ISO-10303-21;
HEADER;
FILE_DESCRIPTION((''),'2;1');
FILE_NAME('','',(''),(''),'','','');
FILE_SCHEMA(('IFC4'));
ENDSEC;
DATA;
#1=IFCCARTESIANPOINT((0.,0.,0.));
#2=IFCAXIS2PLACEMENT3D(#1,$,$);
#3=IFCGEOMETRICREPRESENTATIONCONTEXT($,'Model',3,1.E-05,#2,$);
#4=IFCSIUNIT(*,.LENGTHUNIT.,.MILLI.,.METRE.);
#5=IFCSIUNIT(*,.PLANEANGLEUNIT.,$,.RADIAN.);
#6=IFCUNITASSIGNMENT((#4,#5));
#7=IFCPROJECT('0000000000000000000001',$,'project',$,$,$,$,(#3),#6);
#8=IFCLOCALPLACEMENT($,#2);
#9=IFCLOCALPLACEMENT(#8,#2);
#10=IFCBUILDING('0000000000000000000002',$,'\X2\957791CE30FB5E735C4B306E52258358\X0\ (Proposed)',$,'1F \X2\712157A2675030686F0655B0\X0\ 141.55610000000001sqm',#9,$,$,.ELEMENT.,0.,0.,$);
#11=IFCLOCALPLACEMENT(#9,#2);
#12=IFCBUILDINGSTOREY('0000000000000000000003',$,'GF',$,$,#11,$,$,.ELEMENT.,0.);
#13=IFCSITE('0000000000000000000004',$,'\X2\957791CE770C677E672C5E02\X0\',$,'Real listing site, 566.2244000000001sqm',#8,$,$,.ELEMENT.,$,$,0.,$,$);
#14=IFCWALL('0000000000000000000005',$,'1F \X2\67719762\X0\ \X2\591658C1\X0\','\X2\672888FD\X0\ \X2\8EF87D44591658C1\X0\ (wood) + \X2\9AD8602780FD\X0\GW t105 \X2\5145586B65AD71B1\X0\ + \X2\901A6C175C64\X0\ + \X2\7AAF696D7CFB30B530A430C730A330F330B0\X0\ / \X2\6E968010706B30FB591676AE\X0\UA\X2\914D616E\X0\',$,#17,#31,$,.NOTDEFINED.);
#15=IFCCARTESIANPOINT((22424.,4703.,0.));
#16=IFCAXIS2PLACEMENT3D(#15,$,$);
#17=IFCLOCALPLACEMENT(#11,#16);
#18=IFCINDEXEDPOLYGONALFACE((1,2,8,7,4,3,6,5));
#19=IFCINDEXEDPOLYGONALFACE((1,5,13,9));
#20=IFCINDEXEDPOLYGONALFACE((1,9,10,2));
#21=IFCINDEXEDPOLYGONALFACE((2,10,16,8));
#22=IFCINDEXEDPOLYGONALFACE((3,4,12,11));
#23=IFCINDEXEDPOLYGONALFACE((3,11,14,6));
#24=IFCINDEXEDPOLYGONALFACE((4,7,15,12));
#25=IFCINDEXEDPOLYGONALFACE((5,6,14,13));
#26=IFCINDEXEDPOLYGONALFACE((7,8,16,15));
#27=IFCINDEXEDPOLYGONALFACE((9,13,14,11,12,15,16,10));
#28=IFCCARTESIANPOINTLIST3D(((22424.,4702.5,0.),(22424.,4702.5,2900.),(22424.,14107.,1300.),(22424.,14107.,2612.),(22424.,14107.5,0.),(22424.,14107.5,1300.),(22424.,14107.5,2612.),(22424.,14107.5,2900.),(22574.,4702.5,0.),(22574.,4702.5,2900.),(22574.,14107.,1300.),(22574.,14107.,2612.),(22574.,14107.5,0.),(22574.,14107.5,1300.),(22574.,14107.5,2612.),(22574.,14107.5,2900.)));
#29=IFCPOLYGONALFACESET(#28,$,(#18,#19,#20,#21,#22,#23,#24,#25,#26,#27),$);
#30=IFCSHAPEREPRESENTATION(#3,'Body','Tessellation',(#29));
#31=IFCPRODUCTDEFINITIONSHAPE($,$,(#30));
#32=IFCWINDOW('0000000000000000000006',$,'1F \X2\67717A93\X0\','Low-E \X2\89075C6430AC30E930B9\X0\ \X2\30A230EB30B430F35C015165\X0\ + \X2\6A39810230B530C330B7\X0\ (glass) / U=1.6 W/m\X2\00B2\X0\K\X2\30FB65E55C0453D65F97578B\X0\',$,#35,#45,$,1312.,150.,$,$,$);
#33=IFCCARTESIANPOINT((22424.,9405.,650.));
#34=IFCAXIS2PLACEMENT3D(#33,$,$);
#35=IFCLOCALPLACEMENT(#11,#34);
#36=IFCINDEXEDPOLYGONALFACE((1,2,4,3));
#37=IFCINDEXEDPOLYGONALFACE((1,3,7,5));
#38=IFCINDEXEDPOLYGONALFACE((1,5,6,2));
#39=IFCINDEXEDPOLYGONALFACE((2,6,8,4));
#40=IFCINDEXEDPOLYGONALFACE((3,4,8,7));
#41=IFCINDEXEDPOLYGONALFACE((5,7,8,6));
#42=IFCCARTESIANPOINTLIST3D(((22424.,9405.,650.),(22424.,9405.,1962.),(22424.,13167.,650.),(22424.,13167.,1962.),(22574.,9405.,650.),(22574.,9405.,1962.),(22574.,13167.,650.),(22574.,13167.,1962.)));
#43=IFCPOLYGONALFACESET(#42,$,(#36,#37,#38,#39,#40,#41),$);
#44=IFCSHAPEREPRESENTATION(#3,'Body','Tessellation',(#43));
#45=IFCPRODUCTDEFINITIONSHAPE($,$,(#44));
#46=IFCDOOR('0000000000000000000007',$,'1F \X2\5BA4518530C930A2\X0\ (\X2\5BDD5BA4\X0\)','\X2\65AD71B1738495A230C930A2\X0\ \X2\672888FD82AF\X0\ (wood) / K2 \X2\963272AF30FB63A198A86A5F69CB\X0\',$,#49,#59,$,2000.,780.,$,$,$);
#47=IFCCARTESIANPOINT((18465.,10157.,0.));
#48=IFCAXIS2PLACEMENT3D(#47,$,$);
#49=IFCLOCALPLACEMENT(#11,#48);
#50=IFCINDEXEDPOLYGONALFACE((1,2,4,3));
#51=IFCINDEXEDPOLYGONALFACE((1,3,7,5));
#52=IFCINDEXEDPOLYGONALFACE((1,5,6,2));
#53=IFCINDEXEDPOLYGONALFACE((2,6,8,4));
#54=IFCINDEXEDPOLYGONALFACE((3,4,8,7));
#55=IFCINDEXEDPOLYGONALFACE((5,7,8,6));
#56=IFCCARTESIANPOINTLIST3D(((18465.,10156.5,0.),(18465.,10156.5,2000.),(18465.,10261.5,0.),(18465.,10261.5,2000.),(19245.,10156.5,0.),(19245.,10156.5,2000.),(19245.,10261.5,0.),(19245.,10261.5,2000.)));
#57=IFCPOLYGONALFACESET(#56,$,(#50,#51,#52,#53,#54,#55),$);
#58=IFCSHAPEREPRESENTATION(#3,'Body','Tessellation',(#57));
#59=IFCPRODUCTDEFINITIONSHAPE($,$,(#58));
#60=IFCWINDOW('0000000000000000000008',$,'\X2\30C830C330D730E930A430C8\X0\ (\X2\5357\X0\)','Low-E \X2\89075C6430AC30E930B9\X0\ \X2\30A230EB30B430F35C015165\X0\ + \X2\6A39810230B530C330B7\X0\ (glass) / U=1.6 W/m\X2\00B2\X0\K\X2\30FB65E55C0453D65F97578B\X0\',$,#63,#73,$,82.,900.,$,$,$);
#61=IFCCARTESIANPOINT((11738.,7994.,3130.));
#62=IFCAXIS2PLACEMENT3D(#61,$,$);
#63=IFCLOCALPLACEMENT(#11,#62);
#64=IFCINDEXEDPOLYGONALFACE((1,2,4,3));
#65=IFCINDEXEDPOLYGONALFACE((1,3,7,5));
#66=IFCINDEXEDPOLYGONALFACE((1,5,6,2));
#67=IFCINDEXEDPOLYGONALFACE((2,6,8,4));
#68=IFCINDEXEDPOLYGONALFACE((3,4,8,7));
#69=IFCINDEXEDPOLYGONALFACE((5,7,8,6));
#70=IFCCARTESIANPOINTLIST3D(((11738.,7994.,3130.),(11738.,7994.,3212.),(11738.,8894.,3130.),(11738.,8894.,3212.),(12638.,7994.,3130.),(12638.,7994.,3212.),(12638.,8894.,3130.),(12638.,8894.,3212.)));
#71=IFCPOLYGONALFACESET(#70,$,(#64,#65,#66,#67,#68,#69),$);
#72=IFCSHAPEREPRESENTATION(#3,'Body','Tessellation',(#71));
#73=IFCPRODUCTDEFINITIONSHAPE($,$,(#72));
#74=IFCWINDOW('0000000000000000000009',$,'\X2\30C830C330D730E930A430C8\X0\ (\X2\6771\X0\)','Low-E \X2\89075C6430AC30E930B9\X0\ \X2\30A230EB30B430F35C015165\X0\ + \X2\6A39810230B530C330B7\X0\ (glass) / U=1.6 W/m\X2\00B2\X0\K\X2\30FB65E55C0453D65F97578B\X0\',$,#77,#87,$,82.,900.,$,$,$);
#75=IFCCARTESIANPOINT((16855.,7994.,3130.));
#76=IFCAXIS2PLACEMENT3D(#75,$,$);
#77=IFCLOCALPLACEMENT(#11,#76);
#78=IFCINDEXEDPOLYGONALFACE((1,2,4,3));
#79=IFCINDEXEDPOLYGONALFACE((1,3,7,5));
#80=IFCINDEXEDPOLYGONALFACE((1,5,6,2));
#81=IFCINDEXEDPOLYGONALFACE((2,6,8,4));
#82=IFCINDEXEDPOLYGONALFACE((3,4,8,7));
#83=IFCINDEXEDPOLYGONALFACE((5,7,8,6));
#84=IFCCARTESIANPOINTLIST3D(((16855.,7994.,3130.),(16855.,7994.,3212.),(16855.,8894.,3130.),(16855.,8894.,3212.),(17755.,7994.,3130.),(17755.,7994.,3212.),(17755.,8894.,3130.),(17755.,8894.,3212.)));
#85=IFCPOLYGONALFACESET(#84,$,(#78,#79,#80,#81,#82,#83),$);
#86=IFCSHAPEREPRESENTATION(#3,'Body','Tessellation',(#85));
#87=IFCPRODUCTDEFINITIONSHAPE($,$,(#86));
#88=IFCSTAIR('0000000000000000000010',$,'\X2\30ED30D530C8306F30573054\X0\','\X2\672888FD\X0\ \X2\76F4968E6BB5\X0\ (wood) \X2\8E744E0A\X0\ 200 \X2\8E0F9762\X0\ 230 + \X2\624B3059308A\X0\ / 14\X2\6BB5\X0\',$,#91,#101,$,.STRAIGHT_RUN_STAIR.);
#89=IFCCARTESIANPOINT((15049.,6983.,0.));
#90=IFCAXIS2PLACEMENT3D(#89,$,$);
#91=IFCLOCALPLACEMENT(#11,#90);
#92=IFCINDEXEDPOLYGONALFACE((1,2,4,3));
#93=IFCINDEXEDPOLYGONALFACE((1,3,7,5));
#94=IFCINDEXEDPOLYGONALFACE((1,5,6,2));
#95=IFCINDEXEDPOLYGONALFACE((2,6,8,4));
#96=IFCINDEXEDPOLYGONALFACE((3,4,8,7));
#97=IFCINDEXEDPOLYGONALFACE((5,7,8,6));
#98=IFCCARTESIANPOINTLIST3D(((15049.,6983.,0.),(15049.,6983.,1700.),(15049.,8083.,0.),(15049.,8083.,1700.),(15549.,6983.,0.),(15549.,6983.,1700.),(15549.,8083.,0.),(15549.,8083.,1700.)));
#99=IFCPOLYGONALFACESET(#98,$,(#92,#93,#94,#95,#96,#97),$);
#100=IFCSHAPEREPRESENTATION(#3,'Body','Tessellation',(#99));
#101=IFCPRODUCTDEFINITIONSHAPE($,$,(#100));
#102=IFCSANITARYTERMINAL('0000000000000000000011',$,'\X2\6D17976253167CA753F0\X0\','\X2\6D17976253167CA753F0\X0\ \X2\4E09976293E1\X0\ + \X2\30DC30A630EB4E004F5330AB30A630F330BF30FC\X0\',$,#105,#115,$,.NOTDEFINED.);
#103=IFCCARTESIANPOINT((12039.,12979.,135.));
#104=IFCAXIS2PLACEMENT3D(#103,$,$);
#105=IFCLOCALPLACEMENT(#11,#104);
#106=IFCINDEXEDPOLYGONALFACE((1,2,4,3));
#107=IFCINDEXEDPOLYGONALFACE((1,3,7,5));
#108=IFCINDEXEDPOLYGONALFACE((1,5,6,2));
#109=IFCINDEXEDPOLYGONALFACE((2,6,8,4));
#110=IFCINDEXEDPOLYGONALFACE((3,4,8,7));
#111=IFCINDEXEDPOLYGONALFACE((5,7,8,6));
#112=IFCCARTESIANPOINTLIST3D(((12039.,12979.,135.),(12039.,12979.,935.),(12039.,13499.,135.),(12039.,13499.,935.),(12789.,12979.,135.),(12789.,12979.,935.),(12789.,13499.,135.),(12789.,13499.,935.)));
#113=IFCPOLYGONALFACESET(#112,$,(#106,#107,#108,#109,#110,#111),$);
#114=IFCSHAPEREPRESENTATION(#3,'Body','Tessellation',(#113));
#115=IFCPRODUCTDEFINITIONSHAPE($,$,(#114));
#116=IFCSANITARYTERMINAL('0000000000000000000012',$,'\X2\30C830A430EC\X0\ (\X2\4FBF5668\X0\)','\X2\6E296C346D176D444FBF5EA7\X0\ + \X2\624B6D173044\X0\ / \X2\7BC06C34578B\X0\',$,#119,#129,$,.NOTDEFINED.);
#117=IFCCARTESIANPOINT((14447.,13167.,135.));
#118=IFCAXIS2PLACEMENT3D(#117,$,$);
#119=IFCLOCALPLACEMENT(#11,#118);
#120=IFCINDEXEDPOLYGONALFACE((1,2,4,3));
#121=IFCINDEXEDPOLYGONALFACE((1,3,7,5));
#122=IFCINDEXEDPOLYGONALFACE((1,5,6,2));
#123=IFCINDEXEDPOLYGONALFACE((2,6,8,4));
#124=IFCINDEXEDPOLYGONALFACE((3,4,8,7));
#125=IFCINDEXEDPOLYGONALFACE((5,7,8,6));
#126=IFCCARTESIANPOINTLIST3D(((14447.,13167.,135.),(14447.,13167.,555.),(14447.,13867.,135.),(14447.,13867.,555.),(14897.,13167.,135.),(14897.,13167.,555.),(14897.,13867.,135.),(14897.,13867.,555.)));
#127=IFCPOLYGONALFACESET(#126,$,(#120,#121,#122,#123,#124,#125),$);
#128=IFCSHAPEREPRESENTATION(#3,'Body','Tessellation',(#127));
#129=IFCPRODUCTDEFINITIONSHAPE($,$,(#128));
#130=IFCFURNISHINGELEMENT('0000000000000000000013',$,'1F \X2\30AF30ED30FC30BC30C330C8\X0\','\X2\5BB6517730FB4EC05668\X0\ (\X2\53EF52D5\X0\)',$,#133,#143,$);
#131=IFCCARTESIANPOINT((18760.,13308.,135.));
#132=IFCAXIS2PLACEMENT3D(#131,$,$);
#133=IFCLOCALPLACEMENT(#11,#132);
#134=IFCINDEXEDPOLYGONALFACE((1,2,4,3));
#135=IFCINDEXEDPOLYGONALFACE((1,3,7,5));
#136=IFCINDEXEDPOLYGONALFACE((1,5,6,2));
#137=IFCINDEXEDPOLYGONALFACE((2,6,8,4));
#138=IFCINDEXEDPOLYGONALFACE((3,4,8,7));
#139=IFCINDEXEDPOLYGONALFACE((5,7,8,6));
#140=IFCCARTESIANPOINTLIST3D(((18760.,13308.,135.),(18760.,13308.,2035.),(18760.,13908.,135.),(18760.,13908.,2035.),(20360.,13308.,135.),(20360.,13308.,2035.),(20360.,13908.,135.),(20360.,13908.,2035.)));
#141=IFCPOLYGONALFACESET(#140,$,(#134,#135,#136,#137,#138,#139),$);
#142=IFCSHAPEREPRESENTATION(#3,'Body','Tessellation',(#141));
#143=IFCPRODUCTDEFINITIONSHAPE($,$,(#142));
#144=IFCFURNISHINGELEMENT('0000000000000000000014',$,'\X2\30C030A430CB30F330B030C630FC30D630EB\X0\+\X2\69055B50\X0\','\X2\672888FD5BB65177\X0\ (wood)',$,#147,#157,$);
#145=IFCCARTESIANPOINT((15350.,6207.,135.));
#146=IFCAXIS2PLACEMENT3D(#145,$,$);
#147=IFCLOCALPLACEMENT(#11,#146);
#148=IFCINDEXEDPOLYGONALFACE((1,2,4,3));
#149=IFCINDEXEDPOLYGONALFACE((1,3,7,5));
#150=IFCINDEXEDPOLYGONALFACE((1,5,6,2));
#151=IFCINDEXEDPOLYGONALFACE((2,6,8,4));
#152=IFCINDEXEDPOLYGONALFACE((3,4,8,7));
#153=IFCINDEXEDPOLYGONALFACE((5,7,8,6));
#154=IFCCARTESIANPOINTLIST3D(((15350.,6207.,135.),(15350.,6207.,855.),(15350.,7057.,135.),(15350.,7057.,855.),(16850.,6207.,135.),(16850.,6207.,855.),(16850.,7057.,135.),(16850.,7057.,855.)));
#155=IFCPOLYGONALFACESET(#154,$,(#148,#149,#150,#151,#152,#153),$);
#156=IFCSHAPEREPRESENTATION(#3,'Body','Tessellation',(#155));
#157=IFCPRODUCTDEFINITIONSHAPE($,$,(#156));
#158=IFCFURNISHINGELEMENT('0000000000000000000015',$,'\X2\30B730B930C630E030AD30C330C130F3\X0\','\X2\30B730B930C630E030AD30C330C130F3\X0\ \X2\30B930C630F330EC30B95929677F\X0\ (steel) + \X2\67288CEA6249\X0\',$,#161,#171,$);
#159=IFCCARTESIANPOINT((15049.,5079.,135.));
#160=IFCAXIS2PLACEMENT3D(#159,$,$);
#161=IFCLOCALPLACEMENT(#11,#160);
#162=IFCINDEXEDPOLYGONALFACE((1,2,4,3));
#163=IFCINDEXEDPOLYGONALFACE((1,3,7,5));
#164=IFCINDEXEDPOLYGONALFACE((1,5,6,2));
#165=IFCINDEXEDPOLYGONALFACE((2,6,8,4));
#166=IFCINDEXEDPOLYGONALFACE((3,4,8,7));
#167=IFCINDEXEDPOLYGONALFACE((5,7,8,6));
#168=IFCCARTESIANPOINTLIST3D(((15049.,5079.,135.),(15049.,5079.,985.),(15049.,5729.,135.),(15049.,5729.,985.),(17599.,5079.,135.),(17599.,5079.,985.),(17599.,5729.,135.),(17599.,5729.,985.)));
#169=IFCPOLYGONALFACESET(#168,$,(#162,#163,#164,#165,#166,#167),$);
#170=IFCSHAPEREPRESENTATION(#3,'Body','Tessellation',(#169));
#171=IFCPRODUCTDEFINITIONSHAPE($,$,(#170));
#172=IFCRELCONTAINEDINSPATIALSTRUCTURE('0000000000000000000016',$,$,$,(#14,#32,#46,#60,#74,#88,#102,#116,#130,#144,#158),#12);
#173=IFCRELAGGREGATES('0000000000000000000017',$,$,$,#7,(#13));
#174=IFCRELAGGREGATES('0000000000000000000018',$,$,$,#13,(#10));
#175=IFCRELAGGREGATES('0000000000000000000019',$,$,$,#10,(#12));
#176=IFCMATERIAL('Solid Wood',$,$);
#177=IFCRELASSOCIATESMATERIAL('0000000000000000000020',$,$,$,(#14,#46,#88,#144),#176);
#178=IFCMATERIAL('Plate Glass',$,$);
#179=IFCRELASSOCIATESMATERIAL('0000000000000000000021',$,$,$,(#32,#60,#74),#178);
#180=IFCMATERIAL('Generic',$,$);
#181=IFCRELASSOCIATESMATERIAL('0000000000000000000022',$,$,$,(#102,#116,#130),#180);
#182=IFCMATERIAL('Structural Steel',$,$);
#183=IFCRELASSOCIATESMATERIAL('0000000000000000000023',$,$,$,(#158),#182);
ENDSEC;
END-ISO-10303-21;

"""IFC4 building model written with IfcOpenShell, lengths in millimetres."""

from ifc_helpers import new_model, si_unit, frame, frame_2d, origin, place, context, project, spatial, rectangle, extrude, material, element, fill, save


model = new_model("IFC4")

# Units and contexts
model_context = context("Model", 3, precision=1e-05, world=origin())
ifc_project = project(units=[si_unit("LENGTHUNIT", "METRE", prefix="MILLI"), si_unit("PLANEANGLEUNIT", "RADIAN")], contexts=[model_context])

# Site, building, storey
site_placement = place(None, origin())
site = spatial("IfcSite", under=ifc_project, at=site_placement, Name="長野県松本市", ObjectType="Real listing site, 566.2244000000001sqm", CompositionType="ELEMENT", RefElevation=0.0)
building_placement = place(site_placement, origin())
building = spatial("IfcBuilding", under=site, at=building_placement, Name="長野・平屋の別荘 (Proposed)", ObjectType="1F 無垢材と漆喰 141.55610000000001sqm", CompositionType="ELEMENT", ElevationOfRefHeight=0.0, ElevationOfTerrain=0.0)
storey_placement = place(building_placement, origin())
storey = spatial("IfcBuildingStorey", under=building, at=storey_placement, Name="GF", CompositionType="ELEMENT", Elevation=0.0)

# Wall, opening, window
ifc_material_1 = material(Name="Solid Wood")
wall_1_placement = place(storey_placement, frame((22424.0, 4703.0, 0.0)))
wall_1 = element("IfcWall", 1, at=wall_1_placement, inside=storey, material=ifc_material_1, Name="1F 東面 外壁", Description="木製 軸組外壁 (wood) + 高性能GW t105 充填断熱 + 通気層 + 窯業系サイディング / 準耐火・外皮UA配慮", PredefinedType="NOTDEFINED", context=model_context, shape_type="SweptSolid", body=[
    extrude(rectangle(XDim=150.0, YDim=9405.0, at=frame_2d((75.0, 4702.0))), frame((22424.0, 4703.0, 0.0)), (0.0, 0.0, 1.0), 2900.0),
])
opening_placement = place(storey_placement, frame((22424.0, 9405.0, 650.0)))
opening = element("IfcOpeningElement", 2, at=opening_placement, cuts=wall_1, PredefinedType="NOTDEFINED", context=model_context, shape_type="SweptSolid", body=[
    extrude(rectangle(XDim=150.0, YDim=3762.0, at=frame_2d((75.0, 1881.0))), frame((22424.0, 9405.0, 650.0)), (0.0, 0.0, 1.0), 1312.0),
])
ifc_material_2 = material(Name="Plate Glass")
window_1_placement = place(storey_placement, frame((22424.0, 9405.0, 650.0)))
window_1 = element("IfcWindow", 3, at=window_1_placement, inside=storey, material=ifc_material_2, Name="1F 東窓", Description="Low-E 複層ガラス アルゴン封入 + 樹脂サッシ (glass) / U=1.6 W/m²K・日射取得型", OverallHeight=1312.0, OverallWidth=150.0, context=model_context, shape_type="SweptSolid", body=[
    extrude(rectangle(XDim=150.0, YDim=3762.0, at=frame_2d((75.0, 1881.0))), frame((22424.0, 9405.0, 650.0)), (0.0, 0.0, 1.0), 1312.0),
])
fill(opening, window_1)

# Door
door_placement = place(storey_placement, frame((18465.0, 10157.0, 0.0)))
element("IfcDoor", 4, at=door_placement, inside=storey, material=ifc_material_1, Name="1F 室内ドア (寝室)", Description="断熱玄関ドア 木製芯 (wood) / K2 防犯・採風機構", OverallHeight=2000.0, OverallWidth=780.0, context=model_context, shape_type="SweptSolid", body=[
    extrude(rectangle(XDim=780.0, YDim=105.0, at=frame_2d((390.0, 52.0))), frame((18465.0, 10157.0, 0.0)), (0.0, 0.0, 1.0), 2000.0),
])

# Windows
window_2_placement = place(storey_placement, frame((11738.0, 7994.0, 3130.0)))
element("IfcWindow", 5, at=window_2_placement, inside=storey, material=ifc_material_2, Name="トップライト (南)", Description="Low-E 複層ガラス アルゴン封入 + 樹脂サッシ (glass) / U=1.6 W/m²K・日射取得型", OverallHeight=82.0, OverallWidth=900.0, context=model_context, shape_type="SweptSolid", body=[
    extrude(rectangle(XDim=900.0, YDim=900.0, at=frame_2d((450.0, 450.0))), frame((11738.0, 7994.0, 3130.0)), (0.0, 0.0, 1.0), 82.0),
])
window_3_placement = place(storey_placement, frame((16855.0, 7994.0, 3130.0)))
element("IfcWindow", 6, at=window_3_placement, inside=storey, material=ifc_material_2, Name="トップライト (東)", Description="Low-E 複層ガラス アルゴン封入 + 樹脂サッシ (glass) / U=1.6 W/m²K・日射取得型", OverallHeight=82.0, OverallWidth=900.0, context=model_context, shape_type="SweptSolid", body=[
    extrude(rectangle(XDim=900.0, YDim=900.0, at=frame_2d((450.0, 450.0))), frame((16855.0, 7994.0, 3130.0)), (0.0, 0.0, 1.0), 82.0),
])

# Stair
stair_placement = place(storey_placement, frame((15049.0, 6983.0, 0.0)))
element("IfcStair", 7, at=stair_placement, inside=storey, material=ifc_material_1, Name="ロフトはしご", Description="木製 直階段 (wood) 蹴上 200 踏面 230 + 手すり / 14段", PredefinedType="STRAIGHT_RUN_STAIR", context=model_context, shape_type="SweptSolid", body=[
    extrude(rectangle(XDim=500.0, YDim=1100.0, at=frame_2d((250.0, 550.0))), frame((15049.0, 6983.0, 0.0)), (0.0, 0.0, 1.0), 1700.0),
])

# Sanitary terminals
ifc_material_3 = material(Name="Generic")
sanitary_terminal_1_placement = place(storey_placement, frame((12039.0, 12979.0, 135.0)))
element("IfcSanitaryTerminal", 8, at=sanitary_terminal_1_placement, inside=storey, material=ifc_material_3, Name="洗面化粧台", Description="洗面化粧台 三面鏡 + ボウル一体カウンター", PredefinedType="NOTDEFINED", context=model_context, shape_type="SweptSolid", body=[
    extrude(rectangle(XDim=750.0, YDim=520.0, at=frame_2d((375.0, 260.0))), frame((12039.0, 12979.0, 135.0)), (0.0, 0.0, 1.0), 800.0),
])
sanitary_terminal_2_placement = place(storey_placement, frame((14447.0, 13167.0, 135.0)))
element("IfcSanitaryTerminal", 9, at=sanitary_terminal_2_placement, inside=storey, material=ifc_material_3, Name="トイレ (便器)", Description="温水洗浄便座 + 手洗い / 節水型", PredefinedType="NOTDEFINED", context=model_context, shape_type="SweptSolid", body=[
    extrude(rectangle(XDim=450.0, YDim=700.0, at=frame_2d((225.0, 350.0))), frame((14447.0, 13167.0, 135.0)), (0.0, 0.0, 1.0), 420.0),
])

# Furnishing elements
furnishing_1_placement = place(storey_placement, frame((18760.0, 13308.0, 135.0)))
element("IfcFurnishingElement", 10, at=furnishing_1_placement, inside=storey, material=ifc_material_3, Name="1F クローゼット", Description="家具・什器 (可動)", context=model_context, shape_type="SweptSolid", body=[
    extrude(rectangle(XDim=1600.0, YDim=600.0, at=frame_2d((800.0, 300.0))), frame((18760.0, 13308.0, 135.0)), (0.0, 0.0, 1.0), 1900.0),
])
furnishing_2_placement = place(storey_placement, frame((15350.0, 6207.0, 135.0)))
element("IfcFurnishingElement", 11, at=furnishing_2_placement, inside=storey, material=ifc_material_1, Name="ダイニングテーブル+椅子", Description="木製家具 (wood)", context=model_context, shape_type="SweptSolid", body=[
    extrude(rectangle(XDim=1500.0, YDim=850.0, at=frame_2d((750.0, 425.0))), frame((15350.0, 6207.0, 135.0)), (0.0, 0.0, 1.0), 720.0),
])
ifc_material_4 = material(Name="Structural Steel")
furnishing_3_placement = place(storey_placement, frame((15049.0, 5079.0, 135.0)))
element("IfcFurnishingElement", 12, at=furnishing_3_placement, inside=storey, material=ifc_material_4, Name="システムキッチン", Description="システムキッチン ステンレス天板 (steel) + 木質扉", context=model_context, shape_type="SweptSolid", body=[
    extrude(rectangle(XDim=2550.0, YDim=650.0, at=frame_2d((1275.0, 325.0))), frame((15049.0, 5079.0, 135.0)), (0.0, 0.0, 1.0), 850.0),
])

save(model, "model.ifc")
